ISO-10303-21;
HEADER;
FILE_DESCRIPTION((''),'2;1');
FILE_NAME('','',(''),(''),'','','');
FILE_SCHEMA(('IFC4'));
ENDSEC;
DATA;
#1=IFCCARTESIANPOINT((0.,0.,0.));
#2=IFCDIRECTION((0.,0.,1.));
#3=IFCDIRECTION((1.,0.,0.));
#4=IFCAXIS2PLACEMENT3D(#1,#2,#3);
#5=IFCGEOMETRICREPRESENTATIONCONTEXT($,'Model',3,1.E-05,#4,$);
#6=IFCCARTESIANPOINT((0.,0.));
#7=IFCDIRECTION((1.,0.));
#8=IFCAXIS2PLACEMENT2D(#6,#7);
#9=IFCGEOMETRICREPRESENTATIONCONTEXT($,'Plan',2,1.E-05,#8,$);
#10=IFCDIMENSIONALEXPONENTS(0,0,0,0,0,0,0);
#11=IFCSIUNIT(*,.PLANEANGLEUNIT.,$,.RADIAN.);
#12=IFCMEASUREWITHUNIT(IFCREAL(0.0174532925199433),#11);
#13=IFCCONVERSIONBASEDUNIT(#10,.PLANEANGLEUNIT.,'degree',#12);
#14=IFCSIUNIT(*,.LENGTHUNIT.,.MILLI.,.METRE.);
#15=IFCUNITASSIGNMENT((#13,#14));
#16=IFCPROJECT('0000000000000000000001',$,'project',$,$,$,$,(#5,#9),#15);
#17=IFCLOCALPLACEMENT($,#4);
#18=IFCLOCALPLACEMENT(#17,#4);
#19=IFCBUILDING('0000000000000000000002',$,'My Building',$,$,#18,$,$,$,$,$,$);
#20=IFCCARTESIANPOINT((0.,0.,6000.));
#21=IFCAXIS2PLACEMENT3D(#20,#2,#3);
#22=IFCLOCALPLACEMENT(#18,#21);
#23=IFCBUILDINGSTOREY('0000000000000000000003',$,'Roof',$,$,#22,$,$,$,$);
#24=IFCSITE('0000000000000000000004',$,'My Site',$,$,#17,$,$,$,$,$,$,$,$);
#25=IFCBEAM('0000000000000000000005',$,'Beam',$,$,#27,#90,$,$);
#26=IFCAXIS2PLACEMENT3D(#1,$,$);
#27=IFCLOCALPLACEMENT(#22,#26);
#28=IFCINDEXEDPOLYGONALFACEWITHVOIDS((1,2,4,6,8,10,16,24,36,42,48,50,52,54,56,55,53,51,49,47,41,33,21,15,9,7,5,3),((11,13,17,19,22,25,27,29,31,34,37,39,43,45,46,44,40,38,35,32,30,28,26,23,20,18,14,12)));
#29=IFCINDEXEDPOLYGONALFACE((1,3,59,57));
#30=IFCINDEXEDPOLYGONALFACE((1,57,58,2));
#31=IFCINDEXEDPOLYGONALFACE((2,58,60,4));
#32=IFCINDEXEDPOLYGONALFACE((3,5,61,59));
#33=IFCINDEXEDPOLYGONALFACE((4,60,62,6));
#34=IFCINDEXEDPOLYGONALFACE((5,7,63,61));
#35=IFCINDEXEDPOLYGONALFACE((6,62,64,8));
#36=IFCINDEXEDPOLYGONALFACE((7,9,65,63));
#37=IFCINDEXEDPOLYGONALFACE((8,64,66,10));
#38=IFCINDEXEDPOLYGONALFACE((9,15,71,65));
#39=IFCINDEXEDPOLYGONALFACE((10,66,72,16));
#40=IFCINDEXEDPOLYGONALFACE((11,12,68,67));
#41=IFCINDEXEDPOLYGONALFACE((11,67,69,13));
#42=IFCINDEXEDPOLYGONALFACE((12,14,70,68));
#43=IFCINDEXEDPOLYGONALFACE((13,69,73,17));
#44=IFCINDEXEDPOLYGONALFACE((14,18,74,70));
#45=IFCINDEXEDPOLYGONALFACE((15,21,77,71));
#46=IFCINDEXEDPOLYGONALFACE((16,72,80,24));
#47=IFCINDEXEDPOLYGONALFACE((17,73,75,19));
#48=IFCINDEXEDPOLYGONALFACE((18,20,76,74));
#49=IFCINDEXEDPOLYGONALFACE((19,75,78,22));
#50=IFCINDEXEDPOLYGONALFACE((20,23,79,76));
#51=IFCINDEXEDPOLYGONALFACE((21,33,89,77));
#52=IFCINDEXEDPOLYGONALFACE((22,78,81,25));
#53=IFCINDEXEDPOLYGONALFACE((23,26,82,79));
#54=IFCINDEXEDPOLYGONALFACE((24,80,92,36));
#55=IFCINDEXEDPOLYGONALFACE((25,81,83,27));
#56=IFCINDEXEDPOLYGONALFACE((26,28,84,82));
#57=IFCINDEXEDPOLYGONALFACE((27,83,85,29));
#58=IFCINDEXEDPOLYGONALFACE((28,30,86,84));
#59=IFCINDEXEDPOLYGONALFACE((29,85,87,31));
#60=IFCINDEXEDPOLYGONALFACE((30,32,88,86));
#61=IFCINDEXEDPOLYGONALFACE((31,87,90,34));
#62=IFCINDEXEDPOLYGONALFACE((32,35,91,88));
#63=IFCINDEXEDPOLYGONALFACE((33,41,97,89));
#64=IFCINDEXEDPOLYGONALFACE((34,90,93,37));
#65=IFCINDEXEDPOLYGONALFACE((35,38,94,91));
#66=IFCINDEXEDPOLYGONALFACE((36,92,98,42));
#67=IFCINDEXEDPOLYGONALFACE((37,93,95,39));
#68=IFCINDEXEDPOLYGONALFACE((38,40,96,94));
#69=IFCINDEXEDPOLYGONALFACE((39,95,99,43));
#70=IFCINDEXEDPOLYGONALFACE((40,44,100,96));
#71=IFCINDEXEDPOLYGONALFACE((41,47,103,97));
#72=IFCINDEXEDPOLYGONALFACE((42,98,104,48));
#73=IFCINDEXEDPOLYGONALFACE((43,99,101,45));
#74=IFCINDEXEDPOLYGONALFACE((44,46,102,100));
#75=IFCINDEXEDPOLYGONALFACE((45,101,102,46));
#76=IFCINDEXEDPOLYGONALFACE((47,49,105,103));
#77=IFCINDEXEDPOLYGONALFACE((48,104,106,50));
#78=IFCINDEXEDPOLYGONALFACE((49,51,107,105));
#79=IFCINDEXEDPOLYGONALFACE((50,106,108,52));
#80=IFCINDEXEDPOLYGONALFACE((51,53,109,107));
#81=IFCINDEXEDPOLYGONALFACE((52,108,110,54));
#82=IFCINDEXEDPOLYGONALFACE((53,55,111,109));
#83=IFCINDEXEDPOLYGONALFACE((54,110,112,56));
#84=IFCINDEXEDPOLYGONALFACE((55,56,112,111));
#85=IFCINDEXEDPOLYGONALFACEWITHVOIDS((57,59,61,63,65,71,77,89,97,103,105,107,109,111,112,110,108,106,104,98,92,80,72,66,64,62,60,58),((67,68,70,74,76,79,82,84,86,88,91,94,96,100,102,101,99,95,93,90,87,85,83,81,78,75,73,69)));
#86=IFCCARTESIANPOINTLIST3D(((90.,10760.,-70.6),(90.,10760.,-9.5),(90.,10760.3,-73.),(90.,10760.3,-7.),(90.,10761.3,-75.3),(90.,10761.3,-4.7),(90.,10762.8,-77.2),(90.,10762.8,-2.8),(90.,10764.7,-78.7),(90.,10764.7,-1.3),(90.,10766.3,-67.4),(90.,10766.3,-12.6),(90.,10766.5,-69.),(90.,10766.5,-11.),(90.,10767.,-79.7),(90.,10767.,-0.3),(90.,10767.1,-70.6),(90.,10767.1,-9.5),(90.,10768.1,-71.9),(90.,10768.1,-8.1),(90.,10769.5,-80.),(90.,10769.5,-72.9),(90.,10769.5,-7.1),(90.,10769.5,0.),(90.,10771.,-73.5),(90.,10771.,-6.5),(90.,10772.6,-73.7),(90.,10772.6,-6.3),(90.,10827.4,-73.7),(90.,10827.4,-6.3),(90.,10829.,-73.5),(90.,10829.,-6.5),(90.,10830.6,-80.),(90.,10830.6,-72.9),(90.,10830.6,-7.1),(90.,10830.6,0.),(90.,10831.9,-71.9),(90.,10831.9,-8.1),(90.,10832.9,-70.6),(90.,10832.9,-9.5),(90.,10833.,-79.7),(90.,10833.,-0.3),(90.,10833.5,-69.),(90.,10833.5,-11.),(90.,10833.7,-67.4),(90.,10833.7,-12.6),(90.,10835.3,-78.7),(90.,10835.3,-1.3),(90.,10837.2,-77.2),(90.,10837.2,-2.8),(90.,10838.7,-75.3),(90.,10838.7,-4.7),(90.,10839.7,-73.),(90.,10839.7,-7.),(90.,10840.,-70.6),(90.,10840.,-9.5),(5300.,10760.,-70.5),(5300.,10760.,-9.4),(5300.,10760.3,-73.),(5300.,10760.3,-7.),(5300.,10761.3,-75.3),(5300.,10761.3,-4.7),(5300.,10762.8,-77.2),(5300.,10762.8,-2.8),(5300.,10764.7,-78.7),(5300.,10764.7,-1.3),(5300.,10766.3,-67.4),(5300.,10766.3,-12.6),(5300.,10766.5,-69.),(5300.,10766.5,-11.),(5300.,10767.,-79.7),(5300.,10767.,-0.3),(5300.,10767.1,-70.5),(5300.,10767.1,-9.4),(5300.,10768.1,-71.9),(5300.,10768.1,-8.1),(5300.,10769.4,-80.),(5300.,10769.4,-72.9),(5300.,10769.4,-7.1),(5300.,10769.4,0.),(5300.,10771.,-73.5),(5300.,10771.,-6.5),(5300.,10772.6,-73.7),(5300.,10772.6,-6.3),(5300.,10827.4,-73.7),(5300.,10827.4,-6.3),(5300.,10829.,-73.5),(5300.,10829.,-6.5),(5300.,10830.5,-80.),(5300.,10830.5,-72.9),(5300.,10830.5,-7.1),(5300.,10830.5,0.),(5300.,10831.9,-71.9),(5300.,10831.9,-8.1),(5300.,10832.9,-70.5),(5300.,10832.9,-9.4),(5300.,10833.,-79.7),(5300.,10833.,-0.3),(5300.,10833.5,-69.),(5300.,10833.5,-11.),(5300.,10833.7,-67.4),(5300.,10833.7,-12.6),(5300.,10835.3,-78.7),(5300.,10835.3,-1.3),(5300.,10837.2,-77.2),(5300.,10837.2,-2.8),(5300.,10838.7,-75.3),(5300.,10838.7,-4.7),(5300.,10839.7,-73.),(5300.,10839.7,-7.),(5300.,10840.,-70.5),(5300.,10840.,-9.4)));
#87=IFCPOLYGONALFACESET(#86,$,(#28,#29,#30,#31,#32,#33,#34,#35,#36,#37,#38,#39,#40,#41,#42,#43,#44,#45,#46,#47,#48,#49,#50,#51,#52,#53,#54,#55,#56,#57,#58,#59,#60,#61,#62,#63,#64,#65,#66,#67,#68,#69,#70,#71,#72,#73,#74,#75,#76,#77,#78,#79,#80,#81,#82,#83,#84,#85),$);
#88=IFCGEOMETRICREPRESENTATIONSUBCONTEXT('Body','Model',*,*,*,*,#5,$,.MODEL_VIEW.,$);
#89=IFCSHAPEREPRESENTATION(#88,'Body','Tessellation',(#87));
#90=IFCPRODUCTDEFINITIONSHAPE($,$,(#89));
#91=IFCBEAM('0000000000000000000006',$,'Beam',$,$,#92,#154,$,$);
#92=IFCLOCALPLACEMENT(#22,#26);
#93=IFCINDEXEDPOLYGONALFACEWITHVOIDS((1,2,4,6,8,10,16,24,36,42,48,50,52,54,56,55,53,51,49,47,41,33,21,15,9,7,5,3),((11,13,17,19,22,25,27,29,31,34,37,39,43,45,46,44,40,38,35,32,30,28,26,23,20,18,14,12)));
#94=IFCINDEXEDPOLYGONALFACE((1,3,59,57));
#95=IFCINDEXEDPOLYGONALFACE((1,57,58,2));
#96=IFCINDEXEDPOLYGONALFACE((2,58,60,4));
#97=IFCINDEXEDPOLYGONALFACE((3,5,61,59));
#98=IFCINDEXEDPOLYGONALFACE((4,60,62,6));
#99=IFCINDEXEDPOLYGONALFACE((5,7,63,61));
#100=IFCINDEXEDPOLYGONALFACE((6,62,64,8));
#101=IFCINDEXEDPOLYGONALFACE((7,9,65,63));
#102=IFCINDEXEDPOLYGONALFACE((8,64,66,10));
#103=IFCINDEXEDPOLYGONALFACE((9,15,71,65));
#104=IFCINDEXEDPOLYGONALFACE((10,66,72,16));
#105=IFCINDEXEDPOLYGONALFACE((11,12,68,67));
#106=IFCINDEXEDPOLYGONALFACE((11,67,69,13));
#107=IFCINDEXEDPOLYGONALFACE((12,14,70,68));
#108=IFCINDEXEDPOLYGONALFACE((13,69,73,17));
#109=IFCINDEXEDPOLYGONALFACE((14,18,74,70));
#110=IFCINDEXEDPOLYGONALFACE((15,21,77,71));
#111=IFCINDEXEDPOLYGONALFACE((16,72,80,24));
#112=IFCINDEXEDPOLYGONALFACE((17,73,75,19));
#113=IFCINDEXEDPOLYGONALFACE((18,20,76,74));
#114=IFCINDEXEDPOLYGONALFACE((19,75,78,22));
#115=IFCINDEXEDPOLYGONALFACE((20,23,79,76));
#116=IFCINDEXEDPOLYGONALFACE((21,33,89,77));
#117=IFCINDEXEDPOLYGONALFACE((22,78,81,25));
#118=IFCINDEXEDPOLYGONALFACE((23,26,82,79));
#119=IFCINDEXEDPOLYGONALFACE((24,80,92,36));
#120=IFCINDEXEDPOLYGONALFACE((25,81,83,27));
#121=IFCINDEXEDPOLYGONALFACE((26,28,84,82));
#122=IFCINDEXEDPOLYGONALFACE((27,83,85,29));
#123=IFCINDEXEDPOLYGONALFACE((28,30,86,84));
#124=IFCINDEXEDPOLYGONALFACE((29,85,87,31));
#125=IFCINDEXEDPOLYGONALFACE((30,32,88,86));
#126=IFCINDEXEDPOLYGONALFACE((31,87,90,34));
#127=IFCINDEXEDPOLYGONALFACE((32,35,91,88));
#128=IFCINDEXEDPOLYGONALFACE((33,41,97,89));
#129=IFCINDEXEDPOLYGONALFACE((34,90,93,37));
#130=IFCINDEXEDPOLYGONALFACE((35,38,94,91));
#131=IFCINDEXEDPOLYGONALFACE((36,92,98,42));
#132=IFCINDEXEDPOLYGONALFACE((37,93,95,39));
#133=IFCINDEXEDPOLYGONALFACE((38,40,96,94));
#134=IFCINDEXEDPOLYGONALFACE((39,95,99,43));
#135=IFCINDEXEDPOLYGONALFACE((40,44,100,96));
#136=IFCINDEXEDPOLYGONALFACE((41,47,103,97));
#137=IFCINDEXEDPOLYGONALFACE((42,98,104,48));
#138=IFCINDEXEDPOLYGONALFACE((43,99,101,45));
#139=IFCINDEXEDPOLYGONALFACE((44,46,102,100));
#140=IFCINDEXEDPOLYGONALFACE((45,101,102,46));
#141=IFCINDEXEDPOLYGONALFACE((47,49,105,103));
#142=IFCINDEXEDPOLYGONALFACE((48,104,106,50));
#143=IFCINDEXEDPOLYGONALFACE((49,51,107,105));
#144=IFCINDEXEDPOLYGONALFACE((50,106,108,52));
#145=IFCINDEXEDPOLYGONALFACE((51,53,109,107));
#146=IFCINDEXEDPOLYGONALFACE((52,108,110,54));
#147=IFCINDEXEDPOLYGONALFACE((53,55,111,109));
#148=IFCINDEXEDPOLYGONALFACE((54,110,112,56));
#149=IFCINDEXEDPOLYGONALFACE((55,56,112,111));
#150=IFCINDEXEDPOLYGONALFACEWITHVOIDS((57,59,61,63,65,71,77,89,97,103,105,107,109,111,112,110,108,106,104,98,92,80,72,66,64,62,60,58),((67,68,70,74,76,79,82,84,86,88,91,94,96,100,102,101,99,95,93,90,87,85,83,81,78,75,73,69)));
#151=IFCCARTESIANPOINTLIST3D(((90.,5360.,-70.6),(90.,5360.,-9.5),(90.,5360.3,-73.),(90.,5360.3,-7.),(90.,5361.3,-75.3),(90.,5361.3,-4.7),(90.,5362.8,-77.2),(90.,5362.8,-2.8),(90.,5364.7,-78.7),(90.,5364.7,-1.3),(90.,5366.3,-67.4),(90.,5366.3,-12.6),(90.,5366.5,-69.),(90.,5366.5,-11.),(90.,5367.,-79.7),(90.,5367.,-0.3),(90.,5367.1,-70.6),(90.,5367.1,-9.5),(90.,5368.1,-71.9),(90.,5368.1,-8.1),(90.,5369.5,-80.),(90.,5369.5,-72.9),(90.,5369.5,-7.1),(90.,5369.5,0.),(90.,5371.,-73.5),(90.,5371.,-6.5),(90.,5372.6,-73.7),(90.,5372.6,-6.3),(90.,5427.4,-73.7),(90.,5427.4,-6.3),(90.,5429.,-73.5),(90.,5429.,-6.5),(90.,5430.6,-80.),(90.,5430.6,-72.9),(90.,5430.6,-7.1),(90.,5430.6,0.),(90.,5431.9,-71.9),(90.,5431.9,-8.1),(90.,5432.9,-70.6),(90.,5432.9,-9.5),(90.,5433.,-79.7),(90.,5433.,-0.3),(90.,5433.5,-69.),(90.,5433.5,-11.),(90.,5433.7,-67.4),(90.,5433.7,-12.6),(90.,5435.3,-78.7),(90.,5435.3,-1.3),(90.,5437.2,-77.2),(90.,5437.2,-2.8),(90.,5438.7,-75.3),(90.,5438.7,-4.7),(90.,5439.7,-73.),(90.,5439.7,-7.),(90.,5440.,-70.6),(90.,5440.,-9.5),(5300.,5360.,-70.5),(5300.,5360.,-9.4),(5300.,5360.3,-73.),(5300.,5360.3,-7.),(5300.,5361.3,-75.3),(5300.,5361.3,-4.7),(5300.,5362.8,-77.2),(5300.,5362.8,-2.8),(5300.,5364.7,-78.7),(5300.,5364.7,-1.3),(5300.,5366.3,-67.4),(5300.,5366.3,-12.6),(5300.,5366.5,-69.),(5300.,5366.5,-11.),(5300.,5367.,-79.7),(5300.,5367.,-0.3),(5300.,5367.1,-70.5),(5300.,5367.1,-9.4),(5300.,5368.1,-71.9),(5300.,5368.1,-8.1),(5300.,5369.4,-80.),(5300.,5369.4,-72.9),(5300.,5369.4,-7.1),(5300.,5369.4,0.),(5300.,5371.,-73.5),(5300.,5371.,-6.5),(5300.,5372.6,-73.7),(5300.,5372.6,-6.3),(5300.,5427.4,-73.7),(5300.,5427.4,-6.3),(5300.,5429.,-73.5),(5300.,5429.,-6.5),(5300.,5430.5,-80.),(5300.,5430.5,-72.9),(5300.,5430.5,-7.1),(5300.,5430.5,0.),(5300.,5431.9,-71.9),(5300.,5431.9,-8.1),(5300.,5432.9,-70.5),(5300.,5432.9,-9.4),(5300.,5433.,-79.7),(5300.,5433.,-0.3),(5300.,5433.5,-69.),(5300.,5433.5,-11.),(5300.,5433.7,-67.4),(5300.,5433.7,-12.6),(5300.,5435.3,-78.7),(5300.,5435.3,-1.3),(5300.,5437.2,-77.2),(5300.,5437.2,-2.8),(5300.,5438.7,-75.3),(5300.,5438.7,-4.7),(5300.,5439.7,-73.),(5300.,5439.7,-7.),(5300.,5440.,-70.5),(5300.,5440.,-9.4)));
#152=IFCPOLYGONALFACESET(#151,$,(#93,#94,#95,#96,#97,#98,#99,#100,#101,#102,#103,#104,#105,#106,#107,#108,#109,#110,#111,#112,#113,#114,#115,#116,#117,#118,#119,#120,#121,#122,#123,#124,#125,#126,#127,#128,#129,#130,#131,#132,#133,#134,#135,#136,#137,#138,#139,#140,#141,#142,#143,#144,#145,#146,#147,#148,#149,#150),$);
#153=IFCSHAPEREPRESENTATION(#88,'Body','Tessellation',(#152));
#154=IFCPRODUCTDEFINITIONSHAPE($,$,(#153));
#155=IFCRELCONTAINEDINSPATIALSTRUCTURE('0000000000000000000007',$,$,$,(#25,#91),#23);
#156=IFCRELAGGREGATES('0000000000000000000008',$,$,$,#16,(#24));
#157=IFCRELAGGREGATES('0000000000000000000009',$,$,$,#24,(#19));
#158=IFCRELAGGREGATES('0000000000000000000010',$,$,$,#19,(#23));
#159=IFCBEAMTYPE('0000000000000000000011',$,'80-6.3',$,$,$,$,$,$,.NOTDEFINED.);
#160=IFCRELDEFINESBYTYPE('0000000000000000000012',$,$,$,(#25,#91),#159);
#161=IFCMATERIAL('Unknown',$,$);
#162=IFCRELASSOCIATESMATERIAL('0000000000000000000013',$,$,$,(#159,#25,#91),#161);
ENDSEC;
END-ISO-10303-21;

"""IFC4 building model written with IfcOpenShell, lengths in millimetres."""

from ifc_helpers import new_model, entity, si_unit, converted_unit, frame, origin_with_axes, origin_2d_with_axis, place, context, subcontext, project, spatial, hollow_rectangle, extrude, material, material_profile, profile_set, profile_usage, type_object, element, save


model = new_model("IFC4")

# Units and contexts
model_context = context("Model", 3, precision=1e-05, world=origin_with_axes())
plan_context = context("Plan", 2, precision=1e-05, world=origin_2d_with_axis())
body_context = subcontext(model_context, "Body", "Model", "MODEL_VIEW")
ifc_project = project(units=[converted_unit("PLANEANGLEUNIT", "degree", entity("IfcReal", 0.0174532925199433), si_unit("PLANEANGLEUNIT", "RADIAN"), dimensions=[0, 0, 0, 0, 0, 0, 0]), si_unit("LENGTHUNIT", "METRE", prefix="MILLI")], contexts=[model_context, plan_context])

# Site, building, storey
site_placement = place(None, origin_with_axes())
site = spatial("IfcSite", under=ifc_project, at=site_placement, Name="My Site")
building_placement = place(site_placement, origin_with_axes())
building = spatial("IfcBuilding", under=site, at=building_placement, Name="My Building")
storey_placement = place(building_placement, frame((0.0, 0.0, 6000.0), z_axis=(0.0, 0.0, 1.0), x_axis=(1.0, 0.0, 0.0)))
storey = spatial("IfcBuildingStorey", under=building, at=storey_placement, Name="Roof")

# Beams
ifc_material = material(Name="Unknown")
ifc_material_profile_1 = material_profile(ifc_material, hollow_rectangle(XDim=80.0, YDim=80.0, WallThickness=6.3, InnerFilletRadius=6.3, OuterFilletRadius=9.4))
ifc_profile_set_1 = profile_set([ifc_material_profile_1])
ifc_profile_usage_1 = profile_usage(ifc_profile_set_1, cardinal=8)
beam_type_1 = type_object("IfcBeamType", Name="80-6.3", PredefinedType="NOTDEFINED", material=ifc_profile_set_1)
beam_1_placement = place(storey_placement, frame((90.0, 10800.0, 0.0), z_axis=(1.0, 0.0, 0.0), x_axis=(0.0, 1.0, 0.0)))
element("IfcBeam", 1, at=beam_1_placement, inside=storey, type_object=beam_type_1, material=ifc_profile_usage_1, Name="Beam", context=body_context, shape_type="SweptSolid", body=[
    extrude(hollow_rectangle(XDim=80.0, YDim=80.0, WallThickness=6.3, InnerFilletRadius=6.3, OuterFilletRadius=9.4), frame((0.0, -40.0, 0.0), z_axis=(0.0, 0.0, 1.0), x_axis=(1.0, 0.0, 0.0)), (0.0, 0.0, 1.0), 5210.0),
])
ifc_profile_usage_2 = profile_usage(ifc_profile_set_1, cardinal=8)
beam_2_placement = place(storey_placement, frame((90.0, 5400.0, 0.0), z_axis=(1.0, 0.0, 0.0), x_axis=(0.0, 1.0, 0.0)))
element("IfcBeam", 2, at=beam_2_placement, inside=storey, type_object=beam_type_1, material=ifc_profile_usage_2, Name="Beam", context=body_context, shape_type="SweptSolid", body=[
    extrude(hollow_rectangle(XDim=80.0, YDim=80.0, WallThickness=6.3, InnerFilletRadius=6.3, OuterFilletRadius=9.4), frame((0.0, -40.0, 0.0), z_axis=(0.0, 0.0, 1.0), x_axis=(1.0, 0.0, 0.0)), (0.0, 0.0, 1.0), 5210.0),
])

save(model, "model.ifc")
